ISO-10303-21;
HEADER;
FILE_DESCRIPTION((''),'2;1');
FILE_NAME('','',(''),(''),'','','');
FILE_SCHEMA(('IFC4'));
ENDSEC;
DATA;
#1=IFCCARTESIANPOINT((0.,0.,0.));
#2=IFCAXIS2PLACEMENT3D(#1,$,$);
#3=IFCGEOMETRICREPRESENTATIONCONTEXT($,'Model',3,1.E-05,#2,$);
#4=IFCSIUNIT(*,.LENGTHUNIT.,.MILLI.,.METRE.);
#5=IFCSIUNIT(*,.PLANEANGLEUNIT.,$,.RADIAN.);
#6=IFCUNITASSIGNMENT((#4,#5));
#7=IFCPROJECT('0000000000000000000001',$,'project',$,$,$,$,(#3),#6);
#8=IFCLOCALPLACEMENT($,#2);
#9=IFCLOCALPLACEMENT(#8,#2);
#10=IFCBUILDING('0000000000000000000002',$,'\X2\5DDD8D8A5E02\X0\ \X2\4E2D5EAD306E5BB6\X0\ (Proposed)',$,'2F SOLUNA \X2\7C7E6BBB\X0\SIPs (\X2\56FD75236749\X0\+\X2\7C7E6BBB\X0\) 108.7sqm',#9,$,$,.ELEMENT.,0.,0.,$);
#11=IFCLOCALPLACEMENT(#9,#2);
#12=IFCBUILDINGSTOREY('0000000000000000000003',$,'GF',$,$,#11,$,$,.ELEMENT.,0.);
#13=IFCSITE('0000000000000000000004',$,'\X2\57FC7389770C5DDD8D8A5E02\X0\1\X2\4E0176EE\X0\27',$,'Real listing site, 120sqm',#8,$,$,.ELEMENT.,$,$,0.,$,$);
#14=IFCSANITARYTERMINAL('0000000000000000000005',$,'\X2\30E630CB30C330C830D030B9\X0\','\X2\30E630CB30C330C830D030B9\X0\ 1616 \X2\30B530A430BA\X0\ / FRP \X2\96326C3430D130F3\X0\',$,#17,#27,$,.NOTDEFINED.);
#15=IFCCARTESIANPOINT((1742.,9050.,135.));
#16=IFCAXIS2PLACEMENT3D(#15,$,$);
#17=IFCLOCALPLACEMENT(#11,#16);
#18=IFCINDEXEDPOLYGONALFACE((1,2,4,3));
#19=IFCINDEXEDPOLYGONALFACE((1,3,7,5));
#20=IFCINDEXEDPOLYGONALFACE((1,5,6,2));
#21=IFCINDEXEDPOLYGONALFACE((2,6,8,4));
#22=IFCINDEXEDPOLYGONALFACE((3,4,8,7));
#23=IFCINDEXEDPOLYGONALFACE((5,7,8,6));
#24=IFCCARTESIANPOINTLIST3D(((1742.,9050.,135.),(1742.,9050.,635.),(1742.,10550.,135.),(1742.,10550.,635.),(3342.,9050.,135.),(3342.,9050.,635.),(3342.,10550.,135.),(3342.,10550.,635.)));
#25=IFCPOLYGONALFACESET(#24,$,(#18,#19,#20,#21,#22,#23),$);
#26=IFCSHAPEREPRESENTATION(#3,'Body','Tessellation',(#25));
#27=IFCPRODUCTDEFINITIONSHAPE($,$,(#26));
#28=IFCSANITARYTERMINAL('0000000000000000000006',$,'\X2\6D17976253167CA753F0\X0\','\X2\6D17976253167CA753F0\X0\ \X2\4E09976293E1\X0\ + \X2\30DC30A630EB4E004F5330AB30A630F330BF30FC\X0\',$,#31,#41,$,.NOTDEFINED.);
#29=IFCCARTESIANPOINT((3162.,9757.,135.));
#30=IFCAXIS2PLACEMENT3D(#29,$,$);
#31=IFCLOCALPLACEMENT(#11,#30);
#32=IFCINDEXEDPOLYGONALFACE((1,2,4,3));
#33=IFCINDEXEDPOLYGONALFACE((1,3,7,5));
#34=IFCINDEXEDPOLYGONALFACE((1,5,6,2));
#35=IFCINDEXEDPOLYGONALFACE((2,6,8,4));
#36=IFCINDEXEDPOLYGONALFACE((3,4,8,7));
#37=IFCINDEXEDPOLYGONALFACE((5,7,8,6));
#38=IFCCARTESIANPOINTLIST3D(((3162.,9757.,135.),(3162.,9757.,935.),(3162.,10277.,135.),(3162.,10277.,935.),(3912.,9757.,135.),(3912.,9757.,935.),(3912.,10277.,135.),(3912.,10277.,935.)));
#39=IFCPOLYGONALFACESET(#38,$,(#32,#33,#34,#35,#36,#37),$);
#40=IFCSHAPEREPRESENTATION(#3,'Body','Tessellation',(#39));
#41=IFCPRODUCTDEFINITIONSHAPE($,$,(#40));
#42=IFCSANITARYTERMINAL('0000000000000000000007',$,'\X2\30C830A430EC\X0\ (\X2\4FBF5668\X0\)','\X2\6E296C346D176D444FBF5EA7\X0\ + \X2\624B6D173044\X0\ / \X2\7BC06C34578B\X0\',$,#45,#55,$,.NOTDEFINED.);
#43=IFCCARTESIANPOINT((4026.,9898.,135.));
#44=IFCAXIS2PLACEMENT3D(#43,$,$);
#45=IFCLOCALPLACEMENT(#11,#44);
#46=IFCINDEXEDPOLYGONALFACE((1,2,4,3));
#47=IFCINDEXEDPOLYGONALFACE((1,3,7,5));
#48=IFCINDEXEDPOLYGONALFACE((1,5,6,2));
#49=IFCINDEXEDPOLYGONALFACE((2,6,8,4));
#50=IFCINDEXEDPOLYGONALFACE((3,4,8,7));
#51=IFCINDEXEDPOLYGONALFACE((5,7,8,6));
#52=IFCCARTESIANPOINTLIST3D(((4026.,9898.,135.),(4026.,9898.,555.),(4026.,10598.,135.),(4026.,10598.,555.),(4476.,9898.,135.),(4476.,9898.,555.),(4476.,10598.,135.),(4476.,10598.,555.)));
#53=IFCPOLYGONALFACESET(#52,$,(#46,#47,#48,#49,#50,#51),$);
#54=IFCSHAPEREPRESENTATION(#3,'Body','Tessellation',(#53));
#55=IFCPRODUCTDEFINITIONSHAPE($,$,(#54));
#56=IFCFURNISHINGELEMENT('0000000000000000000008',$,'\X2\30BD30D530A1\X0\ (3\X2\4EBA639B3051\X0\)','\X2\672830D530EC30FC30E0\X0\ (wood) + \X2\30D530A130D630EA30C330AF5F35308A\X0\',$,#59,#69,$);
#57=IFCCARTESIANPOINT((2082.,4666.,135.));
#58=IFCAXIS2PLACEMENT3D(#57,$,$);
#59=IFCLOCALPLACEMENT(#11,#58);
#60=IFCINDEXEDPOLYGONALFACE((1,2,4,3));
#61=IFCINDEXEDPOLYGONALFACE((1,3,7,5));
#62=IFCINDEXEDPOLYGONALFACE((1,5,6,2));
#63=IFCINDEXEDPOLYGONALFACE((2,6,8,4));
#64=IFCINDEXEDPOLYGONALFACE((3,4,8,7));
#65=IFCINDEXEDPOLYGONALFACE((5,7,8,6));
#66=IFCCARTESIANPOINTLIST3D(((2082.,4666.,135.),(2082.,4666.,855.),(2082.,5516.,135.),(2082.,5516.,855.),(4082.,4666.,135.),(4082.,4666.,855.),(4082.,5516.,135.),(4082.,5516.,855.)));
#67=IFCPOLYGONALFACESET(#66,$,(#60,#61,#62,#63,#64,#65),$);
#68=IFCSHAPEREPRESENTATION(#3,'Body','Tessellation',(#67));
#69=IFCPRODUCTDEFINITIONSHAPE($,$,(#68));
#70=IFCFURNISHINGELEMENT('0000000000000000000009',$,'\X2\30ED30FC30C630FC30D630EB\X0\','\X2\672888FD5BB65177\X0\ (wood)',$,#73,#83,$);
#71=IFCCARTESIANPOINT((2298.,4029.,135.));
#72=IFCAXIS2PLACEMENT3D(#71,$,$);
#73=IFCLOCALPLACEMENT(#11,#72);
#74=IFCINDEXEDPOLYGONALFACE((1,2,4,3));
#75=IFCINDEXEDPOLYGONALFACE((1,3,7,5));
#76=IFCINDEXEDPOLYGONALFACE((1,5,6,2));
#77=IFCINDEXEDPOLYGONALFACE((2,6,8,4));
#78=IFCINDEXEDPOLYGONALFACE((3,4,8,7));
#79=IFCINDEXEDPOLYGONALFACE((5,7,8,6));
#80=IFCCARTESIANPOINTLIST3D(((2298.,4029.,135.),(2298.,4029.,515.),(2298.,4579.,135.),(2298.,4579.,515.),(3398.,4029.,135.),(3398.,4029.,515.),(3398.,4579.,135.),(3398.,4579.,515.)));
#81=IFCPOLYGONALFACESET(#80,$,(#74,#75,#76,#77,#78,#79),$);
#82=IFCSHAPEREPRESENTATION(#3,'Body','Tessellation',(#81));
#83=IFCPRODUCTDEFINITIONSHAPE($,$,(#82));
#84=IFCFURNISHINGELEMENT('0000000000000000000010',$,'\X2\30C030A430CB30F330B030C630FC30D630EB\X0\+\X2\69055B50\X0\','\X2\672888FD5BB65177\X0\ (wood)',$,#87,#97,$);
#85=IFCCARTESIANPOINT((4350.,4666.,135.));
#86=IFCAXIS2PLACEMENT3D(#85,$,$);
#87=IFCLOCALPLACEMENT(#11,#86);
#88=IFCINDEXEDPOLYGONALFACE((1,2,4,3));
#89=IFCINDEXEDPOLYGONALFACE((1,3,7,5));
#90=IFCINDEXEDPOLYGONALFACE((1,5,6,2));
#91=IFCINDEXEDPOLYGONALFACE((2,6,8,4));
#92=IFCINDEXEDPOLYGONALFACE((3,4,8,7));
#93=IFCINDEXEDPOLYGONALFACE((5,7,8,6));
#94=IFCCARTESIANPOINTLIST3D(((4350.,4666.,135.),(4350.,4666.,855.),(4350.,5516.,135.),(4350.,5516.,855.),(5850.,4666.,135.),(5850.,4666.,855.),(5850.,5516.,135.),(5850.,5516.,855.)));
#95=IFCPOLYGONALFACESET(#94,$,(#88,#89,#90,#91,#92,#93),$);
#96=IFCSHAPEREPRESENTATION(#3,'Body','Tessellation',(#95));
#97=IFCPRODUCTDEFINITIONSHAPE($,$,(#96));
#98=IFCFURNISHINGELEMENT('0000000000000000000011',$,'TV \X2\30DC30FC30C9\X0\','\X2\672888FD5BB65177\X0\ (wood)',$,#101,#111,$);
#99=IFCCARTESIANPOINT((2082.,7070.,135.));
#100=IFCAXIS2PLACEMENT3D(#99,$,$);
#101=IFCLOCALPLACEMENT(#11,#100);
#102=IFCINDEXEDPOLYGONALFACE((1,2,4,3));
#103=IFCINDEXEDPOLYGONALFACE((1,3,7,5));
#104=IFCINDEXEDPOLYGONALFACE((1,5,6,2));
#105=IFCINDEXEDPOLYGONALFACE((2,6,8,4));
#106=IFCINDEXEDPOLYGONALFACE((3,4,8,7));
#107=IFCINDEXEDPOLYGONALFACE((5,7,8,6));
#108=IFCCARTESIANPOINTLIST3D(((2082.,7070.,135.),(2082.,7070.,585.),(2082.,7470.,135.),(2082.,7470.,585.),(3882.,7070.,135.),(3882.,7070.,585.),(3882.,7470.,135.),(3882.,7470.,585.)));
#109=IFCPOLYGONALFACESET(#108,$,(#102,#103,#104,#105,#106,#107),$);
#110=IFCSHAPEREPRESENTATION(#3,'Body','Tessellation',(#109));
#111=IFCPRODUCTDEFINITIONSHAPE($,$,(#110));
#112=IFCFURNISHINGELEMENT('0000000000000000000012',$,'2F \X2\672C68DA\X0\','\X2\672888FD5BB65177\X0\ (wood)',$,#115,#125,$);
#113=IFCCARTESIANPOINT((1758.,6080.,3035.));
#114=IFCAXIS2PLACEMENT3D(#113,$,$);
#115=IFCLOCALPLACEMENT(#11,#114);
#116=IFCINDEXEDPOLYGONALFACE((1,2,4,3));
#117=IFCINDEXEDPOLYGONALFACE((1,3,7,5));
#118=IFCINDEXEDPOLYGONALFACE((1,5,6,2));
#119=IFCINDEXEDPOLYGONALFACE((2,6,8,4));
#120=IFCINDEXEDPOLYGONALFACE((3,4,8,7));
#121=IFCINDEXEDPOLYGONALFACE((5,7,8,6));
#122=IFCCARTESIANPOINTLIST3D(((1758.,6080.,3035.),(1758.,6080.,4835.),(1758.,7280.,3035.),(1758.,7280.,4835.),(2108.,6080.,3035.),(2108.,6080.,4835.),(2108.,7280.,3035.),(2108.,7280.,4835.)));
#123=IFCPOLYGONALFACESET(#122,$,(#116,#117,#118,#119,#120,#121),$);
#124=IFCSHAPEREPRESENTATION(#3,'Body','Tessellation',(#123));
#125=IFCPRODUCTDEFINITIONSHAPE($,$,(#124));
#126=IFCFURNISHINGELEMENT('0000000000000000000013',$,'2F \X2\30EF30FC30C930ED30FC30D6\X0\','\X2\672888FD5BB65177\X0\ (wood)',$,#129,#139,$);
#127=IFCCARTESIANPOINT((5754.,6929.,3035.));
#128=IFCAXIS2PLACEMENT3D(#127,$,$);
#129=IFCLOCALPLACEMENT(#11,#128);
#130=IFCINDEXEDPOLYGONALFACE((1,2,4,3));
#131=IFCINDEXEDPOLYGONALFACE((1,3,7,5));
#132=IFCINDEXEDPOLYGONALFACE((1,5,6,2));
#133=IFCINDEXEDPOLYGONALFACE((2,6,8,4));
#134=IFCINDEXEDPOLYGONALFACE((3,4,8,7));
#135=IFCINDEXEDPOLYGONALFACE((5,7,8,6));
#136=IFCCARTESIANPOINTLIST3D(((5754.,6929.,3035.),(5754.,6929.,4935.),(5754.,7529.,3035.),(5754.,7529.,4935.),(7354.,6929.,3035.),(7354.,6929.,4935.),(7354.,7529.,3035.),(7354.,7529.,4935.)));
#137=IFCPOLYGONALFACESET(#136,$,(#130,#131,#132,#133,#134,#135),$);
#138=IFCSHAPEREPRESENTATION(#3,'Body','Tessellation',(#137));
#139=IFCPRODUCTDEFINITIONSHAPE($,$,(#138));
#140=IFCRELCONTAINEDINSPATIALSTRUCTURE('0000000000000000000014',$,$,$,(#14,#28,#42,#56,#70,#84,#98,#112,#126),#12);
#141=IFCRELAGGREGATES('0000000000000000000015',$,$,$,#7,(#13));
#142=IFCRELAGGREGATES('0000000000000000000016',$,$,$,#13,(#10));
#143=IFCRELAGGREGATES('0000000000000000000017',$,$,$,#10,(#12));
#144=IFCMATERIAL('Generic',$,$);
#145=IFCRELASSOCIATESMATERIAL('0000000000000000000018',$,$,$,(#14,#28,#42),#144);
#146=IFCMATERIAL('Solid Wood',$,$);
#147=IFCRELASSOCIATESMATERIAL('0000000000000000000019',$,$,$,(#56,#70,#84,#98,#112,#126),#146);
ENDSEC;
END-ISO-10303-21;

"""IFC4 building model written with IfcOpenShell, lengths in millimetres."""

from ifc_helpers import new_model, si_unit, frame, frame_2d, origin, place, context, project, spatial, rectangle, extrude, material, element, save


model = new_model("IFC4")

# Units and contexts
model_context = context("Model", 3, precision=1e-05, world=origin())
ifc_project = project(units=[si_unit("LENGTHUNIT", "METRE", prefix="MILLI"), si_unit("PLANEANGLEUNIT", "RADIAN")], contexts=[model_context])

# Site, building, storey
site_placement = place(None, origin())
site = spatial("IfcSite", under=ifc_project, at=site_placement, Name="埼玉県川越市1丁目27", ObjectType="Real listing site, 120sqm", CompositionType="ELEMENT", RefElevation=0.0)
building_placement = place(site_placement, origin())
building = spatial("IfcBuilding", under=site, at=building_placement, Name="川越市 中庭の家 (Proposed)", ObjectType="2F SOLUNA 籾殻SIPs (国産杉+籾殻) 108.7sqm", CompositionType="ELEMENT", ElevationOfRefHeight=0.0, ElevationOfTerrain=0.0)
storey_placement = place(building_placement, origin())
storey = spatial("IfcBuildingStorey", under=building, at=storey_placement, Name="GF", CompositionType="ELEMENT", Elevation=0.0)

# Shared definitions
ifc_material_1 = material(Name="Generic")

# Shared definitions
ifc_material_2 = material(Name="Solid Wood")

# Sanitary terminals
sanitary_terminal_1_placement = place(storey_placement, frame((1742.0, 9050.0, 135.0)))
element("IfcSanitaryTerminal", 1, at=sanitary_terminal_1_placement, inside=storey, material=ifc_material_1, Name="ユニットバス", Description="ユニットバス 1616 サイズ / FRP 防水パン", PredefinedType="NOTDEFINED", context=model_context, shape_type="SweptSolid", body=[
    extrude(rectangle(XDim=1600.0, YDim=1500.0, at=frame_2d((800.0, 750.0))), frame((1742.0, 9050.0, 135.0)), (0.0, 0.0, 1.0), 500.0),
])
sanitary_terminal_2_placement = place(storey_placement, frame((3162.0, 9757.0, 135.0)))
element("IfcSanitaryTerminal", 2, at=sanitary_terminal_2_placement, inside=storey, material=ifc_material_1, Name="洗面化粧台", Description="洗面化粧台 三面鏡 + ボウル一体カウンター", PredefinedType="NOTDEFINED", context=model_context, shape_type="SweptSolid", body=[
    extrude(rectangle(XDim=750.0, YDim=520.0, at=frame_2d((375.0, 260.0))), frame((3162.0, 9757.0, 135.0)), (0.0, 0.0, 1.0), 800.0),
])
sanitary_terminal_3_placement = place(storey_placement, frame((4026.0, 9898.0, 135.0)))
element("IfcSanitaryTerminal", 3, at=sanitary_terminal_3_placement, inside=storey, material=ifc_material_1, Name="トイレ (便器)", Description="温水洗浄便座 + 手洗い / 節水型", PredefinedType="NOTDEFINED", context=model_context, shape_type="SweptSolid", body=[
    extrude(rectangle(XDim=450.0, YDim=700.0, at=frame_2d((225.0, 350.0))), frame((4026.0, 9898.0, 135.0)), (0.0, 0.0, 1.0), 420.0),
])

# Furnishing elements
furnishing_1_placement = place(storey_placement, frame((2082.0, 4666.0, 135.0)))
element("IfcFurnishingElement", 4, at=furnishing_1_placement, inside=storey, material=ifc_material_2, Name="ソファ (3人掛け)", Description="木フレーム (wood) + ファブリック張り", context=model_context, shape_type="SweptSolid", body=[
    extrude(rectangle(XDim=2000.0, YDim=850.0, at=frame_2d((1000.0, 425.0))), frame((2082.0, 4666.0, 135.0)), (0.0, 0.0, 1.0), 720.0),
])
furnishing_2_placement = place(storey_placement, frame((2298.0, 4029.0, 135.0)))
element("IfcFurnishingElement", 5, at=furnishing_2_placement, inside=storey, material=ifc_material_2, Name="ローテーブル", Description="木製家具 (wood)", context=model_context, shape_type="SweptSolid", body=[
    extrude(rectangle(XDim=1100.0, YDim=550.0, at=frame_2d((550.0, 275.0))), frame((2298.0, 4029.0, 135.0)), (0.0, 0.0, 1.0), 380.0),
])
furnishing_3_placement = place(storey_placement, frame((4350.0, 4666.0, 135.0)))
element("IfcFurnishingElement", 6, at=furnishing_3_placement, inside=storey, material=ifc_material_2, Name="ダイニングテーブル+椅子", Description="木製家具 (wood)", context=model_context, shape_type="SweptSolid", body=[
    extrude(rectangle(XDim=1500.0, YDim=850.0, at=frame_2d((750.0, 425.0))), frame((4350.0, 4666.0, 135.0)), (0.0, 0.0, 1.0), 720.0),
])
furnishing_4_placement = place(storey_placement, frame((2082.0, 7070.0, 135.0)))
element("IfcFurnishingElement", 7, at=furnishing_4_placement, inside=storey, material=ifc_material_2, Name="TV ボード", Description="木製家具 (wood)", context=model_context, shape_type="SweptSolid", body=[
    extrude(rectangle(XDim=1800.0, YDim=400.0, at=frame_2d((900.0, 200.0))), frame((2082.0, 7070.0, 135.0)), (0.0, 0.0, 1.0), 450.0),
])
furnishing_5_placement = place(storey_placement, frame((1758.0, 6080.0, 3035.0)))
element("IfcFurnishingElement", 8, at=furnishing_5_placement, inside=storey, material=ifc_material_2, Name="2F 本棚", Description="木製家具 (wood)", context=model_context, shape_type="SweptSolid", body=[
    extrude(rectangle(XDim=350.0, YDim=1200.0, at=frame_2d((175.0, 600.0))), frame((1758.0, 6080.0, 3035.0)), (0.0, 0.0, 1.0), 1800.0),
])
furnishing_6_placement = place(storey_placement, frame((5754.0, 6929.0, 3035.0)))
element("IfcFurnishingElement", 9, at=furnishing_6_placement, inside=storey, material=ifc_material_2, Name="2F ワードローブ", Description="木製家具 (wood)", context=model_context, shape_type="SweptSolid", body=[
    extrude(rectangle(XDim=1600.0, YDim=600.0, at=frame_2d((800.0, 300.0))), frame((5754.0, 6929.0, 3035.0)), (0.0, 0.0, 1.0), 1900.0),
])

save(model, "model.ifc")
